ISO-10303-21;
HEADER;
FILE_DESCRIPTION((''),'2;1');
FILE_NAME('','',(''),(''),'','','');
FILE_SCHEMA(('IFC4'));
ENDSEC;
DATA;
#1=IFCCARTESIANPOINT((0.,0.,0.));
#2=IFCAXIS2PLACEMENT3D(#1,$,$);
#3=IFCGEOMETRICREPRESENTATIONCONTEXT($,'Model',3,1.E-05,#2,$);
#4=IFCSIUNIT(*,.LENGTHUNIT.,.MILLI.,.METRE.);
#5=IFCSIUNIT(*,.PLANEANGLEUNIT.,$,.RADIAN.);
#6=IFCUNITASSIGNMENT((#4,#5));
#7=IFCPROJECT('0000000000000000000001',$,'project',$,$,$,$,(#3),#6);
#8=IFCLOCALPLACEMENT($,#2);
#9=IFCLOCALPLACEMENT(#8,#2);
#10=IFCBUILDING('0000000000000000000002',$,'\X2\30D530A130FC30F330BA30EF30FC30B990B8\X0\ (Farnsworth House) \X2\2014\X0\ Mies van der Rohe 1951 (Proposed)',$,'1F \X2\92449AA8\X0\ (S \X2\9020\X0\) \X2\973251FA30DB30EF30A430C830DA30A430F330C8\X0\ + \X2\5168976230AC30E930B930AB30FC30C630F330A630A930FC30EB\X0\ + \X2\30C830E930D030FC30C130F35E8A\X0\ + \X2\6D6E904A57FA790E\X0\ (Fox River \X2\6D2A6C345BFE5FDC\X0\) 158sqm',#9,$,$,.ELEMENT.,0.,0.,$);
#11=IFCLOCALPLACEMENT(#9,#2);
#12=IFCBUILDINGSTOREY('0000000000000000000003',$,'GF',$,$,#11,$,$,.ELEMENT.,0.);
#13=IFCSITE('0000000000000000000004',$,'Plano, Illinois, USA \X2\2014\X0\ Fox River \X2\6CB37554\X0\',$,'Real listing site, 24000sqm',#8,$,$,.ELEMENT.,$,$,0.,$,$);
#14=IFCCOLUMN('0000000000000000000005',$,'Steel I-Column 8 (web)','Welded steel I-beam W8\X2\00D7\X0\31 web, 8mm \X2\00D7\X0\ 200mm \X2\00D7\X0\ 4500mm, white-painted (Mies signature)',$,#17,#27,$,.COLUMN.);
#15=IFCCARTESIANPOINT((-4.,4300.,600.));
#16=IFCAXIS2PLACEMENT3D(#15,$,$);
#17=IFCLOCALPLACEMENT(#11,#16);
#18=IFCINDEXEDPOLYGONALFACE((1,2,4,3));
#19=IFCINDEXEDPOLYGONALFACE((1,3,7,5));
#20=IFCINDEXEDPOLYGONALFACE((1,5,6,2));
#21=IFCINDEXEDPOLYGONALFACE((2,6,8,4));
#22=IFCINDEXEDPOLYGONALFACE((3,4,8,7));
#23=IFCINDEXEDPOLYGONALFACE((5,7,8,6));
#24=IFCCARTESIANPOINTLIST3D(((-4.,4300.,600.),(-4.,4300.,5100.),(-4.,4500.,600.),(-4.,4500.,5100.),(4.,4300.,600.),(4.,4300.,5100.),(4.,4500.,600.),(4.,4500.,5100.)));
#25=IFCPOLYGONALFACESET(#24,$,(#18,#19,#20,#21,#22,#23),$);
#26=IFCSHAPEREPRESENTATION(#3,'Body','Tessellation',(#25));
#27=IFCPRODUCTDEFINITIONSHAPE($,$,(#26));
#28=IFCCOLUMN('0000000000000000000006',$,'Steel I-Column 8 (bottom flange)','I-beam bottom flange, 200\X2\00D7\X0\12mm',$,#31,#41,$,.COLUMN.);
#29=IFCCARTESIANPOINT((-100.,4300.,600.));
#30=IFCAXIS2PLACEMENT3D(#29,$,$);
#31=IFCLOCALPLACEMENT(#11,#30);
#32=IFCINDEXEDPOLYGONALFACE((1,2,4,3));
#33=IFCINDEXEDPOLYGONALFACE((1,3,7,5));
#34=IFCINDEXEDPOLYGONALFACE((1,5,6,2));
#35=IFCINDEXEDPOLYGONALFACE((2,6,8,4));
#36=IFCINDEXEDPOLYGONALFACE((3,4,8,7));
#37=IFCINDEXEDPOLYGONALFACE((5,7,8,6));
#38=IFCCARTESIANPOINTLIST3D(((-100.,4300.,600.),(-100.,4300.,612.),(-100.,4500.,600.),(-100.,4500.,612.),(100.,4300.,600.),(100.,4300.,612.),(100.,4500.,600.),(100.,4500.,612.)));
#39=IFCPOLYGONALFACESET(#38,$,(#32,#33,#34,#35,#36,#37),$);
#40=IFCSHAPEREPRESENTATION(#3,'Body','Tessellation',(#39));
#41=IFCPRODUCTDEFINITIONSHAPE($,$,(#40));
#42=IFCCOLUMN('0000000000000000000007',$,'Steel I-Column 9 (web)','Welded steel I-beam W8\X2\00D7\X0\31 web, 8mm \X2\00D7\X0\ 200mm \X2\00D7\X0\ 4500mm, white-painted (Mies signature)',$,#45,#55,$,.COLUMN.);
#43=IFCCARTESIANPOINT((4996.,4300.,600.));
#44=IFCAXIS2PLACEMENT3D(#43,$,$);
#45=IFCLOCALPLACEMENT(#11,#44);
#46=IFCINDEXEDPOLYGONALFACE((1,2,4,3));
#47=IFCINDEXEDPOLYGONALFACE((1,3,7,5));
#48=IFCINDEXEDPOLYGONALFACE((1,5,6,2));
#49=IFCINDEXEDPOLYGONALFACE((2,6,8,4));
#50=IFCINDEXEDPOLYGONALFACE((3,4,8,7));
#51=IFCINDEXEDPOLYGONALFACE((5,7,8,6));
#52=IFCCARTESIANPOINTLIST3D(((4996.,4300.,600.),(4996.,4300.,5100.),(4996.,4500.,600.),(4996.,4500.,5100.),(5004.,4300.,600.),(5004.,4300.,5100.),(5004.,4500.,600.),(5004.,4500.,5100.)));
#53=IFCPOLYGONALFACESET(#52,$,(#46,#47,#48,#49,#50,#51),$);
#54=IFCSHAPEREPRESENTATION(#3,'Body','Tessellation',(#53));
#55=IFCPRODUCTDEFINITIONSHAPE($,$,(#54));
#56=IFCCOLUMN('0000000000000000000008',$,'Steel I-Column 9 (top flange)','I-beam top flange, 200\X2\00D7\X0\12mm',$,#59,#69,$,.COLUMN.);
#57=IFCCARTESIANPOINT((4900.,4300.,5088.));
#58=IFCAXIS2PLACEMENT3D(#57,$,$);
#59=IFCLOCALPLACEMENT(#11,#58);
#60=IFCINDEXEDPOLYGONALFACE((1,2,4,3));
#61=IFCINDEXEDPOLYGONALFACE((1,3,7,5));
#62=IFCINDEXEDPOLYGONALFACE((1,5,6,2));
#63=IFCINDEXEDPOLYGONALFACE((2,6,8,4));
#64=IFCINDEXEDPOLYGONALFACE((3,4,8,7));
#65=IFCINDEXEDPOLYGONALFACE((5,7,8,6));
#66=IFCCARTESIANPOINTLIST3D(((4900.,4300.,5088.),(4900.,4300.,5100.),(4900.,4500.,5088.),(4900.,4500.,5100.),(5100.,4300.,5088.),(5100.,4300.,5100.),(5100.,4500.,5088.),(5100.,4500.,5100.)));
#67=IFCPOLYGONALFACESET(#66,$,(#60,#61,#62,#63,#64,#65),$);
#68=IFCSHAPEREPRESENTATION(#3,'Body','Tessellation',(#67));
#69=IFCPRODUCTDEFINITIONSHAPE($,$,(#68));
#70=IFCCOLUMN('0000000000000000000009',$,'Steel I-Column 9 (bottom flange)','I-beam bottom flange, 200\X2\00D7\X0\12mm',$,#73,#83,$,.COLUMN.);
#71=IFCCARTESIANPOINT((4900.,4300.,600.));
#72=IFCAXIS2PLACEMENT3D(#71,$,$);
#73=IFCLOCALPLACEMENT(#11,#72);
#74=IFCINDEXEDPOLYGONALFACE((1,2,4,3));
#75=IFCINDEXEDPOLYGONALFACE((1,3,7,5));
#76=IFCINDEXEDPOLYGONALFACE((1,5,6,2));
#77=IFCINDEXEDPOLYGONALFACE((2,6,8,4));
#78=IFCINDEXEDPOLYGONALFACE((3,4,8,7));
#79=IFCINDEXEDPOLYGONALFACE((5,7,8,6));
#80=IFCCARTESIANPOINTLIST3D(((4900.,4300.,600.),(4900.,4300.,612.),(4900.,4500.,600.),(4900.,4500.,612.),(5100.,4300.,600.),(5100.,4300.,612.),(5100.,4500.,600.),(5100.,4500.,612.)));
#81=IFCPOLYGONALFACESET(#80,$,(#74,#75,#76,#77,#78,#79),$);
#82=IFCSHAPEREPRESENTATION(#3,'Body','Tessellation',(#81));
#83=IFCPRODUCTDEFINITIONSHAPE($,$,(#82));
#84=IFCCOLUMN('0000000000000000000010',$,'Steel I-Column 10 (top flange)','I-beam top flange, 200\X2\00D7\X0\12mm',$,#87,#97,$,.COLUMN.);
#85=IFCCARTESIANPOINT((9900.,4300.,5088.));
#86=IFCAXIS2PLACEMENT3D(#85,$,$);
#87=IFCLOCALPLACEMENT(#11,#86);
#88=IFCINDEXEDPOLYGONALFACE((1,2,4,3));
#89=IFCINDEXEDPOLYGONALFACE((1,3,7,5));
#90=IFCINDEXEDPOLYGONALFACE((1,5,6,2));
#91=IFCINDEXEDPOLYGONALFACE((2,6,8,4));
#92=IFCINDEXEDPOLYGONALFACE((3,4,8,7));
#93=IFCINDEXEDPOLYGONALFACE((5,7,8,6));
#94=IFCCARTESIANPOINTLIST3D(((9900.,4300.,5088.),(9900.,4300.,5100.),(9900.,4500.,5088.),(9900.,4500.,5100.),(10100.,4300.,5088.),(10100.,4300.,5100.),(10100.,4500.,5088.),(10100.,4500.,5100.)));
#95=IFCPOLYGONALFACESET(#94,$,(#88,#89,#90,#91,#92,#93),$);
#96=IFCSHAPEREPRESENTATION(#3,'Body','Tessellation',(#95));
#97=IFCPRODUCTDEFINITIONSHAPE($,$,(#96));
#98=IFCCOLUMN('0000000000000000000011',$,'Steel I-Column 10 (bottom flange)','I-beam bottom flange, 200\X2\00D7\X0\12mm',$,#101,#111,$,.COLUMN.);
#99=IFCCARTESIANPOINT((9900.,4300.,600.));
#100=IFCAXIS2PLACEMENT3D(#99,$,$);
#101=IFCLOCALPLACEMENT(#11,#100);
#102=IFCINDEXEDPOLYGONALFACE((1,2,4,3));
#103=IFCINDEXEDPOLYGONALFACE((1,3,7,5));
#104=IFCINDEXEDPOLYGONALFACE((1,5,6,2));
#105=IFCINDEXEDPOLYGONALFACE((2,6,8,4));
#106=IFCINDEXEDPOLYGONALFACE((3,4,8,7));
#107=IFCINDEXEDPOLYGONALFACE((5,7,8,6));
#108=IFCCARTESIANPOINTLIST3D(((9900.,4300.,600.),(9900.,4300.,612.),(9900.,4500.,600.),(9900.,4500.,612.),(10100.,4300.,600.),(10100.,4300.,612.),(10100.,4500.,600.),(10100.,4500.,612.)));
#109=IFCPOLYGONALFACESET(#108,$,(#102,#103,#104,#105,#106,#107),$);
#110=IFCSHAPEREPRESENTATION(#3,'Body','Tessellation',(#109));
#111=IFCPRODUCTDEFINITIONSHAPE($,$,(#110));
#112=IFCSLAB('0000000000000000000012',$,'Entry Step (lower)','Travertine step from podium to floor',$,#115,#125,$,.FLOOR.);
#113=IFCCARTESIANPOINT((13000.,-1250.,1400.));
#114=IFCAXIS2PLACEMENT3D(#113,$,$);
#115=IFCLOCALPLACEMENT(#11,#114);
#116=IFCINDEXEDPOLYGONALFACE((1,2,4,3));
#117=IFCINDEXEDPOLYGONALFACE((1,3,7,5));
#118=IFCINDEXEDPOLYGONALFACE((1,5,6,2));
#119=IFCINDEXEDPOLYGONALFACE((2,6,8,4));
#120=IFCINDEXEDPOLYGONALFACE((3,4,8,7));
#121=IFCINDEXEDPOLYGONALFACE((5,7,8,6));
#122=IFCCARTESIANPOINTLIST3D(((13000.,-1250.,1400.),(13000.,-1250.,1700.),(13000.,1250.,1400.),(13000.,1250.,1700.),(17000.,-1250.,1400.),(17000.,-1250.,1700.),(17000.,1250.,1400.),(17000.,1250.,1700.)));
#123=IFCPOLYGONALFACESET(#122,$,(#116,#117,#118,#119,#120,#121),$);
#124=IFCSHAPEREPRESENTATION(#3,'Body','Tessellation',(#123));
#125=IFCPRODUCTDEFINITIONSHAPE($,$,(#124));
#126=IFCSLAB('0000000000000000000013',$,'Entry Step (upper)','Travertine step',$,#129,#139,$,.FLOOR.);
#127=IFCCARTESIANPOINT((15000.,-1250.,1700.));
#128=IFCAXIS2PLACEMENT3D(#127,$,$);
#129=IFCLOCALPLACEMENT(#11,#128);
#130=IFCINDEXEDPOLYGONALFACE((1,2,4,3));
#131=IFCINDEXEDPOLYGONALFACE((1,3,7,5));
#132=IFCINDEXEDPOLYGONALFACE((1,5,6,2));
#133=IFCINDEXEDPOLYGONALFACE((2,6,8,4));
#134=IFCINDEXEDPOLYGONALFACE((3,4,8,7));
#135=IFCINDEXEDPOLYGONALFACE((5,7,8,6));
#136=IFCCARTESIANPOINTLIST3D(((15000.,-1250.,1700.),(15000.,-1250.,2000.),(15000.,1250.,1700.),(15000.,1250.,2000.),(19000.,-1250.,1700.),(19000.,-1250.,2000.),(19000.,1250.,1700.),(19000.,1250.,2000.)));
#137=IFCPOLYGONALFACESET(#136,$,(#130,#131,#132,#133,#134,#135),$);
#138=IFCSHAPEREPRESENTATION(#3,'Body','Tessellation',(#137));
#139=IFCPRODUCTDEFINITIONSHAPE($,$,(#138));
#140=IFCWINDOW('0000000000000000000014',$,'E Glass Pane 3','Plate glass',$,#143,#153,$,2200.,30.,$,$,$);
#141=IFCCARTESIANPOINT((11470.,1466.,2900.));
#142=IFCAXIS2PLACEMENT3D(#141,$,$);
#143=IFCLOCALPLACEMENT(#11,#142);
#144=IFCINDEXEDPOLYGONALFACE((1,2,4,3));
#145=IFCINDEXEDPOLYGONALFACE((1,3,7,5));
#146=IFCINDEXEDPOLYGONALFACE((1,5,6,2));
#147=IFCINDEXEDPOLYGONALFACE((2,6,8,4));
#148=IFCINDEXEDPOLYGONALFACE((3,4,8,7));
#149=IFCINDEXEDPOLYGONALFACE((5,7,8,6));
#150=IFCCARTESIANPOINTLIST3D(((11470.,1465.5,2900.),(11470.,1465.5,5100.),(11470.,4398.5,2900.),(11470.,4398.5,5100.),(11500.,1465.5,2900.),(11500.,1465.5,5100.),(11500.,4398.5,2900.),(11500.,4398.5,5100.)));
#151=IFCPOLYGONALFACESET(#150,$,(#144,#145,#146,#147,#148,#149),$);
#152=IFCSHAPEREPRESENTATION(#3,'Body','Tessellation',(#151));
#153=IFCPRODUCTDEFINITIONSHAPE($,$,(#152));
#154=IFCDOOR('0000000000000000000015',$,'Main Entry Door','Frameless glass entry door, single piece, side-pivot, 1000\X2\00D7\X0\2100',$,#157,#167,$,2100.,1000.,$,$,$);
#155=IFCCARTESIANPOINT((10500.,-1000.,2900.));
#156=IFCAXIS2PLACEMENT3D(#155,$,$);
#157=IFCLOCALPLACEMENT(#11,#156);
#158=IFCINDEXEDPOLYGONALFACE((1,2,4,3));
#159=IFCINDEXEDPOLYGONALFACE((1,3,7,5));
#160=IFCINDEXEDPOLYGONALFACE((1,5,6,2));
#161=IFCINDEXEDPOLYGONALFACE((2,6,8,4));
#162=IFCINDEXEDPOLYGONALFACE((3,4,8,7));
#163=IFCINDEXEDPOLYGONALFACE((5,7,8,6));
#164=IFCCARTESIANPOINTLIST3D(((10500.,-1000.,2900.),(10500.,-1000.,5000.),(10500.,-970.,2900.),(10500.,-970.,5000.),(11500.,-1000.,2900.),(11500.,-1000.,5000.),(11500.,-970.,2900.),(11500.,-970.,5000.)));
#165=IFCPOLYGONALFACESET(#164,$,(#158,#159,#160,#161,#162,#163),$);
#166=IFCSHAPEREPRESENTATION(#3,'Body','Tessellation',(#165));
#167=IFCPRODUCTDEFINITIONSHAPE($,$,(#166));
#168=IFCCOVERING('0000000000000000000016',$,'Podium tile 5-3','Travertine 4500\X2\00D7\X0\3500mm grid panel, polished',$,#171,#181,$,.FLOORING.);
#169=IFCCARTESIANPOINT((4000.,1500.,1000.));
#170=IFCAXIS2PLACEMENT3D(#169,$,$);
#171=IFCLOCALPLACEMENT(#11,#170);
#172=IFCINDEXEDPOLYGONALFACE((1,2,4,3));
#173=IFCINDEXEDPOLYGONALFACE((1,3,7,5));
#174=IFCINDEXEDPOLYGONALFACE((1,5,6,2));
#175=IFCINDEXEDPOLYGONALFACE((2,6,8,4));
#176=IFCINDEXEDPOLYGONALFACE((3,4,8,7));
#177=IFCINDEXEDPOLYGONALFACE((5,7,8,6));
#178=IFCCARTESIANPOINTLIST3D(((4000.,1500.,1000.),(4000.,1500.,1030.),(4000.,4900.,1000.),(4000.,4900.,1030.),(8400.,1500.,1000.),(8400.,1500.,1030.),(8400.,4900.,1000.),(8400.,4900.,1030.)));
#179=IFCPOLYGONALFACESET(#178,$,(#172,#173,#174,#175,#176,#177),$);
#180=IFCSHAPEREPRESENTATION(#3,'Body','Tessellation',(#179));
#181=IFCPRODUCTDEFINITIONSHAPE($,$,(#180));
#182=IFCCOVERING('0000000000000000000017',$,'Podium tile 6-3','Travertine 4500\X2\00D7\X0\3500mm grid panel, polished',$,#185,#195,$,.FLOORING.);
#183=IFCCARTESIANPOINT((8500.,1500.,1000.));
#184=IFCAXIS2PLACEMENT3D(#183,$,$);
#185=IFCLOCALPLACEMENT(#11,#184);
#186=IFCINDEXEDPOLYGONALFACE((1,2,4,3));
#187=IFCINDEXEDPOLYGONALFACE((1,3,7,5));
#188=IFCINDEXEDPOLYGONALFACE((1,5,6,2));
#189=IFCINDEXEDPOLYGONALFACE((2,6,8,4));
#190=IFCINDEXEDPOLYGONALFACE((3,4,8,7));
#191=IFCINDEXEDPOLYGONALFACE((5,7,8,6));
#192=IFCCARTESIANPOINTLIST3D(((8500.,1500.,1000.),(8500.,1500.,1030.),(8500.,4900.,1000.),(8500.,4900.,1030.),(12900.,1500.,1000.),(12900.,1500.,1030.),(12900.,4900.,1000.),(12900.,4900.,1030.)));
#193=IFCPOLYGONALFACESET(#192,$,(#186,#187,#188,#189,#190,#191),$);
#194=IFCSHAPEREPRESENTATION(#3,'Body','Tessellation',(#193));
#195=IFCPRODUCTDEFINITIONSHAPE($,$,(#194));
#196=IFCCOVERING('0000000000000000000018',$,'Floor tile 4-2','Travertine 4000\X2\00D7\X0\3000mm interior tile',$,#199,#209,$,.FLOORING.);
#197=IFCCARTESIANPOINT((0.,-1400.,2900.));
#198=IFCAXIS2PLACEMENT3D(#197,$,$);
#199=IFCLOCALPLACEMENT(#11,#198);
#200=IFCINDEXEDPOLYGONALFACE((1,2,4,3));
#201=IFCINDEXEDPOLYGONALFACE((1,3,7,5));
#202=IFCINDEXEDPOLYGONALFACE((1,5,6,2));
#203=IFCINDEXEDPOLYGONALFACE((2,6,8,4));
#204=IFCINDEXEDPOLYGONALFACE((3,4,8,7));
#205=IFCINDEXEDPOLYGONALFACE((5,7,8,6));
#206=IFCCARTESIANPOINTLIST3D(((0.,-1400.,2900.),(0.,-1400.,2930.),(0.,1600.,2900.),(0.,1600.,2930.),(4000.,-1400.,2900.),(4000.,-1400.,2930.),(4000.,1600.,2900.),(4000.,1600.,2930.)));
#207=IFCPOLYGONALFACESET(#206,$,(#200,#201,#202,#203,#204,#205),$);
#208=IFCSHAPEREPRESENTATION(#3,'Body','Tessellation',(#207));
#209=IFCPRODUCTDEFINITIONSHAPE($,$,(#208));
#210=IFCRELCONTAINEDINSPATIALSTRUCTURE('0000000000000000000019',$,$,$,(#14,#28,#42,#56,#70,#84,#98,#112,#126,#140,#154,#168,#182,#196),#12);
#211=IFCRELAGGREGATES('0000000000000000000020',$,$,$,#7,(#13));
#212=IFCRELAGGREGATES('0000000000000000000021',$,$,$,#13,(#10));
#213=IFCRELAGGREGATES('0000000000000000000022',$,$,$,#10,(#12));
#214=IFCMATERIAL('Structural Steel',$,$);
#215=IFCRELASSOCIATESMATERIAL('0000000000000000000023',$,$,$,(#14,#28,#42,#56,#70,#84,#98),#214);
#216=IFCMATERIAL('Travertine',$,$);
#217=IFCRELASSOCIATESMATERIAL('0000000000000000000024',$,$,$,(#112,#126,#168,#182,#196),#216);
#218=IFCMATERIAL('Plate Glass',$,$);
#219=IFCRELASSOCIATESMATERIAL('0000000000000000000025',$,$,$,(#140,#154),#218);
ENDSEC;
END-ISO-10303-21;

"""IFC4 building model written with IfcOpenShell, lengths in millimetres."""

from ifc_helpers import new_model, si_unit, frame, frame_2d, origin, place, context, project, spatial, rectangle, extrude, material, element, save


model = new_model("IFC4")

# Units and contexts
model_context = context("Model", 3, precision=1e-05, world=origin())
ifc_project = project(units=[si_unit("LENGTHUNIT", "METRE", prefix="MILLI"), si_unit("PLANEANGLEUNIT", "RADIAN")], contexts=[model_context])

# Site, building, storey
site_placement = place(None, origin())
site = spatial("IfcSite", under=ifc_project, at=site_placement, Name="Plano, Illinois, USA — Fox River 河畔", ObjectType="Real listing site, 24000sqm", CompositionType="ELEMENT", RefElevation=0.0)
building_placement = place(site_placement, origin())
building = spatial("IfcBuilding", under=site, at=building_placement, Name="ファーンズワース邸 (Farnsworth House) — Mies van der Rohe 1951 (Proposed)", ObjectType="1F 鉄骨 (S 造) 露出ホワイトペイント + 全面ガラスカーテンウォール + トラバーチン床 + 浮遊基礎 (Fox River 洪水対応) 158sqm", CompositionType="ELEMENT", ElevationOfRefHeight=0.0, ElevationOfTerrain=0.0)
storey_placement = place(building_placement, origin())
storey = spatial("IfcBuildingStorey", under=building, at=storey_placement, Name="GF", CompositionType="ELEMENT", Elevation=0.0)

# Columns
ifc_material_1 = material(Name="Structural Steel")
column_1_placement = place(storey_placement, frame((-4.0, 4300.0, 600.0)))
element("IfcColumn", 1, at=column_1_placement, inside=storey, material=ifc_material_1, Name="Steel I-Column 8 (web)", Description="Welded steel I-beam W8×31 web, 8mm × 200mm × 4500mm, white-painted (Mies signature)", PredefinedType="COLUMN", context=model_context, shape_type="SweptSolid", body=[
    extrude(rectangle(XDim=8.0, YDim=200.0, at=frame_2d((4.0, 100.0))), frame((-4.0, 4300.0, 600.0)), (0.0, 0.0, 1.0), 4500.0),
])
column_2_placement = place(storey_placement, frame((-100.0, 4300.0, 600.0)))
element("IfcColumn", 2, at=column_2_placement, inside=storey, material=ifc_material_1, Name="Steel I-Column 8 (bottom flange)", Description="I-beam bottom flange, 200×12mm", PredefinedType="COLUMN", context=model_context, shape_type="SweptSolid", body=[
    extrude(rectangle(XDim=200.0, YDim=200.0, at=frame_2d((100.0, 100.0))), frame((-100.0, 4300.0, 600.0)), (0.0, 0.0, 1.0), 12.0),
])
column_3_placement = place(storey_placement, frame((4996.0, 4300.0, 600.0)))
element("IfcColumn", 3, at=column_3_placement, inside=storey, material=ifc_material_1, Name="Steel I-Column 9 (web)", Description="Welded steel I-beam W8×31 web, 8mm × 200mm × 4500mm, white-painted (Mies signature)", PredefinedType="COLUMN", context=model_context, shape_type="SweptSolid", body=[
    extrude(rectangle(XDim=8.0, YDim=200.0, at=frame_2d((4.0, 100.0))), frame((4996.0, 4300.0, 600.0)), (0.0, 0.0, 1.0), 4500.0),
])
column_4_placement = place(storey_placement, frame((4900.0, 4300.0, 5088.0)))
element("IfcColumn", 4, at=column_4_placement, inside=storey, material=ifc_material_1, Name="Steel I-Column 9 (top flange)", Description="I-beam top flange, 200×12mm", PredefinedType="COLUMN", context=model_context, shape_type="SweptSolid", body=[
    extrude(rectangle(XDim=200.0, YDim=200.0, at=frame_2d((100.0, 100.0))), frame((4900.0, 4300.0, 5088.0)), (0.0, 0.0, 1.0), 12.0),
])
column_5_placement = place(storey_placement, frame((4900.0, 4300.0, 600.0)))
element("IfcColumn", 5, at=column_5_placement, inside=storey, material=ifc_material_1, Name="Steel I-Column 9 (bottom flange)", Description="I-beam bottom flange, 200×12mm", PredefinedType="COLUMN", context=model_context, shape_type="SweptSolid", body=[
    extrude(rectangle(XDim=200.0, YDim=200.0, at=frame_2d((100.0, 100.0))), frame((4900.0, 4300.0, 600.0)), (0.0, 0.0, 1.0), 12.0),
])
column_6_placement = place(storey_placement, frame((9900.0, 4300.0, 5088.0)))
element("IfcColumn", 6, at=column_6_placement, inside=storey, material=ifc_material_1, Name="Steel I-Column 10 (top flange)", Description="I-beam top flange, 200×12mm", PredefinedType="COLUMN", context=model_context, shape_type="SweptSolid", body=[
    extrude(rectangle(XDim=200.0, YDim=200.0, at=frame_2d((100.0, 100.0))), frame((9900.0, 4300.0, 5088.0)), (0.0, 0.0, 1.0), 12.0),
])
column_7_placement = place(storey_placement, frame((9900.0, 4300.0, 600.0)))
element("IfcColumn", 7, at=column_7_placement, inside=storey, material=ifc_material_1, Name="Steel I-Column 10 (bottom flange)", Description="I-beam bottom flange, 200×12mm", PredefinedType="COLUMN", context=model_context, shape_type="SweptSolid", body=[
    extrude(rectangle(XDim=200.0, YDim=200.0, at=frame_2d((100.0, 100.0))), frame((9900.0, 4300.0, 600.0)), (0.0, 0.0, 1.0), 12.0),
])

# Slabs
ifc_material_2 = material(Name="Travertine")
slab_1_placement = place(storey_placement, frame((13000.0, -1250.0, 1400.0)))
element("IfcSlab", 8, at=slab_1_placement, inside=storey, material=ifc_material_2, Name="Entry Step (lower)", Description="Travertine step from podium to floor", PredefinedType="FLOOR", context=model_context, shape_type="SweptSolid", body=[
    extrude(rectangle(XDim=4000.0, YDim=2500.0, at=frame_2d((2000.0, 1250.0))), frame((13000.0, -1250.0, 1400.0)), (0.0, 0.0, 1.0), 300.0),
])
slab_2_placement = place(storey_placement, frame((15000.0, -1250.0, 1700.0)))
element("IfcSlab", 9, at=slab_2_placement, inside=storey, material=ifc_material_2, Name="Entry Step (upper)", Description="Travertine step", PredefinedType="FLOOR", context=model_context, shape_type="SweptSolid", body=[
    extrude(rectangle(XDim=4000.0, YDim=2500.0, at=frame_2d((2000.0, 1250.0))), frame((15000.0, -1250.0, 1700.0)), (0.0, 0.0, 1.0), 300.0),
])

# Window
ifc_material_3 = material(Name="Plate Glass")
window_placement = place(storey_placement, frame((11470.0, 1466.0, 2900.0)))
element("IfcWindow", 10, at=window_placement, inside=storey, material=ifc_material_3, Name="E Glass Pane 3", Description="Plate glass", OverallHeight=2200.0, OverallWidth=30.0, context=model_context, shape_type="SweptSolid", body=[
    extrude(rectangle(XDim=30.0, YDim=2933.0, at=frame_2d((15.0, 1466.0))), frame((11470.0, 1466.0, 2900.0)), (0.0, 0.0, 1.0), 2200.0),
])

# Door
door_placement = place(storey_placement, frame((10500.0, -1000.0, 2900.0)))
element("IfcDoor", 11, at=door_placement, inside=storey, material=ifc_material_3, Name="Main Entry Door", Description="Frameless glass entry door, single piece, side-pivot, 1000×2100", OverallHeight=2100.0, OverallWidth=1000.0, context=model_context, shape_type="SweptSolid", body=[
    extrude(rectangle(XDim=1000.0, YDim=30.0, at=frame_2d((500.0, 15.0))), frame((10500.0, -1000.0, 2900.0)), (0.0, 0.0, 1.0), 2100.0),
])

# Coverings
covering_1_placement = place(storey_placement, frame((4000.0, 1500.0, 1000.0)))
element("IfcCovering", 12, at=covering_1_placement, inside=storey, material=ifc_material_2, Name="Podium tile 5-3", Description="Travertine 4500×3500mm grid panel, polished", PredefinedType="FLOORING", context=model_context, shape_type="SweptSolid", body=[
    extrude(rectangle(XDim=4400.0, YDim=3400.0, at=frame_2d((2200.0, 1700.0))), frame((4000.0, 1500.0, 1000.0)), (0.0, 0.0, 1.0), 30.0),
])
covering_2_placement = place(storey_placement, frame((8500.0, 1500.0, 1000.0)))
element("IfcCovering", 13, at=covering_2_placement, inside=storey, material=ifc_material_2, Name="Podium tile 6-3", Description="Travertine 4500×3500mm grid panel, polished", PredefinedType="FLOORING", context=model_context, shape_type="SweptSolid", body=[
    extrude(rectangle(XDim=4400.0, YDim=3400.0, at=frame_2d((2200.0, 1700.0))), frame((8500.0, 1500.0, 1000.0)), (0.0, 0.0, 1.0), 30.0),
])
covering_3_placement = place(storey_placement, frame((0.0, -1400.0, 2900.0)))
element("IfcCovering", 14, at=covering_3_placement, inside=storey, material=ifc_material_2, Name="Floor tile 4-2", Description="Travertine 4000×3000mm interior tile", PredefinedType="FLOORING", context=model_context, shape_type="SweptSolid", body=[
    extrude(rectangle(XDim=4000.0, YDim=3000.0, at=frame_2d((2000.0, 1500.0))), frame((0.0, -1400.0, 2900.0)), (0.0, 0.0, 1.0), 30.0),
])

save(model, "model.ifc")
